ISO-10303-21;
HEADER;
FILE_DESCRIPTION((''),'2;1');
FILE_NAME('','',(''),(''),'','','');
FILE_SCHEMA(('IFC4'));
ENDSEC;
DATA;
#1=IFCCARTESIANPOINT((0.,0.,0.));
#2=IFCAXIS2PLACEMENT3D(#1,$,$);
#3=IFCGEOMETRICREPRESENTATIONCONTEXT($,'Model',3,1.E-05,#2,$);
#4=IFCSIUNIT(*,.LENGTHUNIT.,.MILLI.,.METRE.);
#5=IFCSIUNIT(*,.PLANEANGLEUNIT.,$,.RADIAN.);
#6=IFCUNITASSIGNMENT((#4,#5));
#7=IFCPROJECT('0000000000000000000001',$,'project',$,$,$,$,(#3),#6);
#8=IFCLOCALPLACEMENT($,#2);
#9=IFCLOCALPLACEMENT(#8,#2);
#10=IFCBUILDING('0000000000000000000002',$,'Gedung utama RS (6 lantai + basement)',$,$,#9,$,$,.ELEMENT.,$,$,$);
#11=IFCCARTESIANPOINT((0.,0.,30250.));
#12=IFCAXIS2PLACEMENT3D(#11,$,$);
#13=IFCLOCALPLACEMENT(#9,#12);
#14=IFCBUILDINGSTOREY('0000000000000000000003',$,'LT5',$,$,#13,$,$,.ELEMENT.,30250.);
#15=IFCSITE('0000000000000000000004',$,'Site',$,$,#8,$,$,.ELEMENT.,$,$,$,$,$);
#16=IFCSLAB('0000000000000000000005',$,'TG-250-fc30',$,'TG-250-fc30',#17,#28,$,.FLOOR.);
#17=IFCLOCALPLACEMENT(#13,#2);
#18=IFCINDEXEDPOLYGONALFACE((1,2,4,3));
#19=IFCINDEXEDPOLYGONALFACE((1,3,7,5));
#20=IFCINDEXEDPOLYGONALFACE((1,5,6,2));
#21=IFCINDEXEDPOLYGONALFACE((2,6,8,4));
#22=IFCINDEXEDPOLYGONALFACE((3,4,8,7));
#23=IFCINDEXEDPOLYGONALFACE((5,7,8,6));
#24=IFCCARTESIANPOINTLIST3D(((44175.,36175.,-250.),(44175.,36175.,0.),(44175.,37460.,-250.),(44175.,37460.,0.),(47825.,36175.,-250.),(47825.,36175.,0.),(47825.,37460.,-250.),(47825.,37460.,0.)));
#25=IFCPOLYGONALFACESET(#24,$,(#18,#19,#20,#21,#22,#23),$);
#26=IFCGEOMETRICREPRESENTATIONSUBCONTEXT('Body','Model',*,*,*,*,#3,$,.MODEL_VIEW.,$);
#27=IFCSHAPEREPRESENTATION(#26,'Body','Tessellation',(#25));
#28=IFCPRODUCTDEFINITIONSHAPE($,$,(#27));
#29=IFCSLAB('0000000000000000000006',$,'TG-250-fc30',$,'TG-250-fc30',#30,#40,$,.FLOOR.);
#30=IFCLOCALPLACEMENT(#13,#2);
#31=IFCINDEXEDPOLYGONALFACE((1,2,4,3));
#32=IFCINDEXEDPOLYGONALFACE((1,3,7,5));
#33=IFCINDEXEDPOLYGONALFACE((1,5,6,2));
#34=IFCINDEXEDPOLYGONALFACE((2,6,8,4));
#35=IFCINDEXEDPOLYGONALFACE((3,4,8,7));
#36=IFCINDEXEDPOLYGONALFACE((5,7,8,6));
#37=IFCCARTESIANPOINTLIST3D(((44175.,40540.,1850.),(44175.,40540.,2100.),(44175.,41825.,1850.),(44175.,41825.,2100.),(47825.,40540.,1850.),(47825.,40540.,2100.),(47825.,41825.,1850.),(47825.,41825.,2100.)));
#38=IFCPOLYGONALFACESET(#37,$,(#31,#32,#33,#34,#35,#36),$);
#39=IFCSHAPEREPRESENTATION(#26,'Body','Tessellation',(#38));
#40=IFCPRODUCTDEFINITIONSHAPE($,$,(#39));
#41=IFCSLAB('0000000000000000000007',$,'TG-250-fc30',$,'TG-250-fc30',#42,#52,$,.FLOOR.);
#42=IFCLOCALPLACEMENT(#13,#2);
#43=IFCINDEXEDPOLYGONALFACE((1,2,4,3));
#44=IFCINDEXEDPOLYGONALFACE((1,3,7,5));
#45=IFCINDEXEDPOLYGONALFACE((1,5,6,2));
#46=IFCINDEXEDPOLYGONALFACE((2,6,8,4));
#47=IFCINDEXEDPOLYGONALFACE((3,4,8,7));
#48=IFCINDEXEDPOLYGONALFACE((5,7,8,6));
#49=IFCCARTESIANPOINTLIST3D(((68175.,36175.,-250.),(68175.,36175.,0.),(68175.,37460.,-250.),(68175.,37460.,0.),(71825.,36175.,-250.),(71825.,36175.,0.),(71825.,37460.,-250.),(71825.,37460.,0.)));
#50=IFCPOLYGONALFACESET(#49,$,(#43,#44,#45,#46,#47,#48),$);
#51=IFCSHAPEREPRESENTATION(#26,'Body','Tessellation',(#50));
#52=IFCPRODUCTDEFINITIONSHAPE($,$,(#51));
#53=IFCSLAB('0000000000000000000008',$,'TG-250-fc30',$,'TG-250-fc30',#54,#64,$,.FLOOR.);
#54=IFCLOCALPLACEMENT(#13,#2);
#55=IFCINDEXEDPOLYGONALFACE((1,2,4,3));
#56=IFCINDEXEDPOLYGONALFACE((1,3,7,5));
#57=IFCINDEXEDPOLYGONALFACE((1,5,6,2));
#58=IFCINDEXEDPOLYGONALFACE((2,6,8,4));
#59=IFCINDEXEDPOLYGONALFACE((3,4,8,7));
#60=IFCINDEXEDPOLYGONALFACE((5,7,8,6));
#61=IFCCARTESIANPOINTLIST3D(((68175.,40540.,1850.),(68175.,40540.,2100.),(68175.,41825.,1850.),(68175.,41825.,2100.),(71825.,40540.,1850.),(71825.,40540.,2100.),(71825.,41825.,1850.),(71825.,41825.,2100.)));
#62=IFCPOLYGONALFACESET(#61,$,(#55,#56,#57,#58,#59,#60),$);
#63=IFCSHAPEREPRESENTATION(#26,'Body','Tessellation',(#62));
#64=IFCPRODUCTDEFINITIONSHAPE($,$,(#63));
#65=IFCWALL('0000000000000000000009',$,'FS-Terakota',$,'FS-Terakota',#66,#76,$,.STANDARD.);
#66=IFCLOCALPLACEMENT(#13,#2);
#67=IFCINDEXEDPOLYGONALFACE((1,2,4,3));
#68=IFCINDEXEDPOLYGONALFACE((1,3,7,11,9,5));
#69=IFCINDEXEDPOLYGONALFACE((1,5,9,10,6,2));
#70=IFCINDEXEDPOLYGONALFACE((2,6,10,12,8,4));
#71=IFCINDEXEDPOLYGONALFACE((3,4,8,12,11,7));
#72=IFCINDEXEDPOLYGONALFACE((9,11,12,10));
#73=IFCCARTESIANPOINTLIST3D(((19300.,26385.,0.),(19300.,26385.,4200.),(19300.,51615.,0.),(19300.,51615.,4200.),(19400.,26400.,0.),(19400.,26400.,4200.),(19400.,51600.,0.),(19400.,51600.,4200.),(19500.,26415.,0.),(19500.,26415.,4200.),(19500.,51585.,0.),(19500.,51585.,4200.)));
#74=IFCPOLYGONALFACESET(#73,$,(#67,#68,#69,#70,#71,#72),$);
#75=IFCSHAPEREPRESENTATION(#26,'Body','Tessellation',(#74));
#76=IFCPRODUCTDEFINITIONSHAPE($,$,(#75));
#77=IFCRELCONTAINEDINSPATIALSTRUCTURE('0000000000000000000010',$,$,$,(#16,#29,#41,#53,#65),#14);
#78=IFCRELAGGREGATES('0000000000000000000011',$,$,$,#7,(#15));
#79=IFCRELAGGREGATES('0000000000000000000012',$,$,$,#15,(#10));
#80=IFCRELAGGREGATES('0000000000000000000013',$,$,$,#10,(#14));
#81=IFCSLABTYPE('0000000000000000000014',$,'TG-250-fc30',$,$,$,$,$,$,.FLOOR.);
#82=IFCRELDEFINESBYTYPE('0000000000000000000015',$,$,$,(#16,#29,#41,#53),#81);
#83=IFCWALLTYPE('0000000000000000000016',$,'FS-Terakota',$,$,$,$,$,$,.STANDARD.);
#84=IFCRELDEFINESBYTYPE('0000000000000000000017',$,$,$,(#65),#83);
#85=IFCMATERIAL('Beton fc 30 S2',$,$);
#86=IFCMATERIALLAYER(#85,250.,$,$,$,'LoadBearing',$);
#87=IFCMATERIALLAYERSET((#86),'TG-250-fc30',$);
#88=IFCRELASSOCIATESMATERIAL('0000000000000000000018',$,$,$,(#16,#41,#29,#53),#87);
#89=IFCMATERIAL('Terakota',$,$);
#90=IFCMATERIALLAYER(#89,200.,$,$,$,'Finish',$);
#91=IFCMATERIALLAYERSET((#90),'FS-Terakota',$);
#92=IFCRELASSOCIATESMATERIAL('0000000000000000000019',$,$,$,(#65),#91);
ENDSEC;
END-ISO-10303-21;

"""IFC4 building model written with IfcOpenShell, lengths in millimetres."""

from ifc_helpers import new_model, si_unit, frame, origin, place, context, subcontext, project, spatial, polyline, outline, extrude, material, layer, layer_set, layer_usage, type_object, element, save


model = new_model("IFC4")

# Units and contexts
model_context = context("Model", 3, precision=1e-05, world=origin())
body_context = subcontext(model_context, "Body", "Model", "MODEL_VIEW")
ifc_project = project(units=[si_unit("LENGTHUNIT", "METRE", prefix="MILLI"), si_unit("PLANEANGLEUNIT", "RADIAN")], contexts=[model_context])

# Site, building, storey
site_placement = place(None, origin())
site = spatial("IfcSite", under=ifc_project, at=site_placement, Name="Site", CompositionType="ELEMENT")
building_placement = place(site_placement, origin())
building = spatial("IfcBuilding", under=site, at=building_placement, Name="Gedung utama RS (6 lantai + basement)", CompositionType="ELEMENT")
storey_placement = place(building_placement, frame((0.0, 0.0, 30250.0)))
storey = spatial("IfcBuildingStorey", under=building, at=storey_placement, Name="LT5", CompositionType="ELEMENT", Elevation=30250.0)

# Shared definitions
ifc_material_1 = material(Name="Beton fc 30 S2")

# Slabs
ifc_layer_1 = layer(ifc_material_1, 250.0, Category="LoadBearing")
ifc_layer_set_1 = layer_set([ifc_layer_1], Name="TG-250-fc30")
ifc_layer_usage_1 = layer_usage(ifc_layer_set_1, "AXIS3", "NEGATIVE", 0.0)
slab_type_1 = type_object("IfcSlabType", Name="TG-250-fc30", PredefinedType="FLOOR")
ifc_layer_usage_2 = layer_usage(ifc_layer_set_1, "AXIS3", "NEGATIVE", 2100.0)
slab_1_placement = place(storey_placement, origin())
element("IfcSlab", 1, at=slab_1_placement, inside=storey, type_object=slab_type_1, material=ifc_layer_usage_1, Name="TG-250-fc30", ObjectType="TG-250-fc30", PredefinedType="FLOOR", context=body_context, shape_type="SweptSolid", body=[
    extrude(outline(polyline([(47825.0, 36175.0), (47825.0, 37460.0), (44175.0, 37460.0), (44175.0, 36175.0), (47825.0, 36175.0)])), frame((0.0, 0.0, -250.0)), (0.0, 0.0, 1.0), 250.0),
])
slab_2_placement = place(storey_placement, origin())
element("IfcSlab", 2, at=slab_2_placement, inside=storey, type_object=slab_type_1, material=ifc_layer_usage_2, Name="TG-250-fc30", ObjectType="TG-250-fc30", PredefinedType="FLOOR", context=body_context, shape_type="SweptSolid", body=[
    extrude(outline(polyline([(47825.0, 40540.0), (47825.0, 41825.0), (44175.0, 41825.0), (44175.0, 40540.0), (47825.0, 40540.0)])), frame((0.0, 0.0, 1850.0)), (0.0, 0.0, 1.0), 250.0),
])
slab_3_placement = place(storey_placement, origin())
element("IfcSlab", 3, at=slab_3_placement, inside=storey, type_object=slab_type_1, material=ifc_layer_usage_1, Name="TG-250-fc30", ObjectType="TG-250-fc30", PredefinedType="FLOOR", context=body_context, shape_type="SweptSolid", body=[
    extrude(outline(polyline([(71825.0, 36175.0), (71825.0, 37460.0), (68175.0, 37460.0), (68175.0, 36175.0), (71825.0, 36175.0)])), frame((0.0, 0.0, -250.0)), (0.0, 0.0, 1.0), 250.0),
])
slab_4_placement = place(storey_placement, origin())
element("IfcSlab", 4, at=slab_4_placement, inside=storey, type_object=slab_type_1, material=ifc_layer_usage_2, Name="TG-250-fc30", ObjectType="TG-250-fc30", PredefinedType="FLOOR", context=body_context, shape_type="SweptSolid", body=[
    extrude(outline(polyline([(71825.0, 40540.0), (71825.0, 41825.0), (68175.0, 41825.0), (68175.0, 40540.0), (71825.0, 40540.0)])), frame((0.0, 0.0, 1850.0)), (0.0, 0.0, 1.0), 250.0),
])

# Wall
ifc_material_2 = material(Name="Terakota")
ifc_layer_2 = layer(ifc_material_2, 200.0, Category="Finish")
ifc_layer_set_2 = layer_set([ifc_layer_2], Name="FS-Terakota")
ifc_layer_usage_3 = layer_usage(ifc_layer_set_2, "AXIS2", "NEGATIVE", 100.0)
wall_type = type_object("IfcWallType", Name="FS-Terakota", PredefinedType="STANDARD")
wall_placement = place(storey_placement, frame((19400.0, 26400.0, 0.0), z_axis=(0.0, 0.0, 1.0), x_axis=(0.0, 1.0, 0.0)))
element("IfcWall", 5, at=wall_placement, inside=storey, type_object=wall_type, material=ifc_layer_usage_3, Name="FS-Terakota", ObjectType="FS-Terakota", PredefinedType="STANDARD", context=body_context, shape_type="SweptSolid", body=[
    extrude(outline(polyline([(15.0, -100.0), (0.0, 0.0), (-15.0, 100.0), (25215.0, 100.0), (25200.0, 0.0), (25185.0, -100.0), (15.0, -100.0)])), origin(), (0.0, 0.0, 1.0), 4200.0),
])

save(model, "model.ifc")
